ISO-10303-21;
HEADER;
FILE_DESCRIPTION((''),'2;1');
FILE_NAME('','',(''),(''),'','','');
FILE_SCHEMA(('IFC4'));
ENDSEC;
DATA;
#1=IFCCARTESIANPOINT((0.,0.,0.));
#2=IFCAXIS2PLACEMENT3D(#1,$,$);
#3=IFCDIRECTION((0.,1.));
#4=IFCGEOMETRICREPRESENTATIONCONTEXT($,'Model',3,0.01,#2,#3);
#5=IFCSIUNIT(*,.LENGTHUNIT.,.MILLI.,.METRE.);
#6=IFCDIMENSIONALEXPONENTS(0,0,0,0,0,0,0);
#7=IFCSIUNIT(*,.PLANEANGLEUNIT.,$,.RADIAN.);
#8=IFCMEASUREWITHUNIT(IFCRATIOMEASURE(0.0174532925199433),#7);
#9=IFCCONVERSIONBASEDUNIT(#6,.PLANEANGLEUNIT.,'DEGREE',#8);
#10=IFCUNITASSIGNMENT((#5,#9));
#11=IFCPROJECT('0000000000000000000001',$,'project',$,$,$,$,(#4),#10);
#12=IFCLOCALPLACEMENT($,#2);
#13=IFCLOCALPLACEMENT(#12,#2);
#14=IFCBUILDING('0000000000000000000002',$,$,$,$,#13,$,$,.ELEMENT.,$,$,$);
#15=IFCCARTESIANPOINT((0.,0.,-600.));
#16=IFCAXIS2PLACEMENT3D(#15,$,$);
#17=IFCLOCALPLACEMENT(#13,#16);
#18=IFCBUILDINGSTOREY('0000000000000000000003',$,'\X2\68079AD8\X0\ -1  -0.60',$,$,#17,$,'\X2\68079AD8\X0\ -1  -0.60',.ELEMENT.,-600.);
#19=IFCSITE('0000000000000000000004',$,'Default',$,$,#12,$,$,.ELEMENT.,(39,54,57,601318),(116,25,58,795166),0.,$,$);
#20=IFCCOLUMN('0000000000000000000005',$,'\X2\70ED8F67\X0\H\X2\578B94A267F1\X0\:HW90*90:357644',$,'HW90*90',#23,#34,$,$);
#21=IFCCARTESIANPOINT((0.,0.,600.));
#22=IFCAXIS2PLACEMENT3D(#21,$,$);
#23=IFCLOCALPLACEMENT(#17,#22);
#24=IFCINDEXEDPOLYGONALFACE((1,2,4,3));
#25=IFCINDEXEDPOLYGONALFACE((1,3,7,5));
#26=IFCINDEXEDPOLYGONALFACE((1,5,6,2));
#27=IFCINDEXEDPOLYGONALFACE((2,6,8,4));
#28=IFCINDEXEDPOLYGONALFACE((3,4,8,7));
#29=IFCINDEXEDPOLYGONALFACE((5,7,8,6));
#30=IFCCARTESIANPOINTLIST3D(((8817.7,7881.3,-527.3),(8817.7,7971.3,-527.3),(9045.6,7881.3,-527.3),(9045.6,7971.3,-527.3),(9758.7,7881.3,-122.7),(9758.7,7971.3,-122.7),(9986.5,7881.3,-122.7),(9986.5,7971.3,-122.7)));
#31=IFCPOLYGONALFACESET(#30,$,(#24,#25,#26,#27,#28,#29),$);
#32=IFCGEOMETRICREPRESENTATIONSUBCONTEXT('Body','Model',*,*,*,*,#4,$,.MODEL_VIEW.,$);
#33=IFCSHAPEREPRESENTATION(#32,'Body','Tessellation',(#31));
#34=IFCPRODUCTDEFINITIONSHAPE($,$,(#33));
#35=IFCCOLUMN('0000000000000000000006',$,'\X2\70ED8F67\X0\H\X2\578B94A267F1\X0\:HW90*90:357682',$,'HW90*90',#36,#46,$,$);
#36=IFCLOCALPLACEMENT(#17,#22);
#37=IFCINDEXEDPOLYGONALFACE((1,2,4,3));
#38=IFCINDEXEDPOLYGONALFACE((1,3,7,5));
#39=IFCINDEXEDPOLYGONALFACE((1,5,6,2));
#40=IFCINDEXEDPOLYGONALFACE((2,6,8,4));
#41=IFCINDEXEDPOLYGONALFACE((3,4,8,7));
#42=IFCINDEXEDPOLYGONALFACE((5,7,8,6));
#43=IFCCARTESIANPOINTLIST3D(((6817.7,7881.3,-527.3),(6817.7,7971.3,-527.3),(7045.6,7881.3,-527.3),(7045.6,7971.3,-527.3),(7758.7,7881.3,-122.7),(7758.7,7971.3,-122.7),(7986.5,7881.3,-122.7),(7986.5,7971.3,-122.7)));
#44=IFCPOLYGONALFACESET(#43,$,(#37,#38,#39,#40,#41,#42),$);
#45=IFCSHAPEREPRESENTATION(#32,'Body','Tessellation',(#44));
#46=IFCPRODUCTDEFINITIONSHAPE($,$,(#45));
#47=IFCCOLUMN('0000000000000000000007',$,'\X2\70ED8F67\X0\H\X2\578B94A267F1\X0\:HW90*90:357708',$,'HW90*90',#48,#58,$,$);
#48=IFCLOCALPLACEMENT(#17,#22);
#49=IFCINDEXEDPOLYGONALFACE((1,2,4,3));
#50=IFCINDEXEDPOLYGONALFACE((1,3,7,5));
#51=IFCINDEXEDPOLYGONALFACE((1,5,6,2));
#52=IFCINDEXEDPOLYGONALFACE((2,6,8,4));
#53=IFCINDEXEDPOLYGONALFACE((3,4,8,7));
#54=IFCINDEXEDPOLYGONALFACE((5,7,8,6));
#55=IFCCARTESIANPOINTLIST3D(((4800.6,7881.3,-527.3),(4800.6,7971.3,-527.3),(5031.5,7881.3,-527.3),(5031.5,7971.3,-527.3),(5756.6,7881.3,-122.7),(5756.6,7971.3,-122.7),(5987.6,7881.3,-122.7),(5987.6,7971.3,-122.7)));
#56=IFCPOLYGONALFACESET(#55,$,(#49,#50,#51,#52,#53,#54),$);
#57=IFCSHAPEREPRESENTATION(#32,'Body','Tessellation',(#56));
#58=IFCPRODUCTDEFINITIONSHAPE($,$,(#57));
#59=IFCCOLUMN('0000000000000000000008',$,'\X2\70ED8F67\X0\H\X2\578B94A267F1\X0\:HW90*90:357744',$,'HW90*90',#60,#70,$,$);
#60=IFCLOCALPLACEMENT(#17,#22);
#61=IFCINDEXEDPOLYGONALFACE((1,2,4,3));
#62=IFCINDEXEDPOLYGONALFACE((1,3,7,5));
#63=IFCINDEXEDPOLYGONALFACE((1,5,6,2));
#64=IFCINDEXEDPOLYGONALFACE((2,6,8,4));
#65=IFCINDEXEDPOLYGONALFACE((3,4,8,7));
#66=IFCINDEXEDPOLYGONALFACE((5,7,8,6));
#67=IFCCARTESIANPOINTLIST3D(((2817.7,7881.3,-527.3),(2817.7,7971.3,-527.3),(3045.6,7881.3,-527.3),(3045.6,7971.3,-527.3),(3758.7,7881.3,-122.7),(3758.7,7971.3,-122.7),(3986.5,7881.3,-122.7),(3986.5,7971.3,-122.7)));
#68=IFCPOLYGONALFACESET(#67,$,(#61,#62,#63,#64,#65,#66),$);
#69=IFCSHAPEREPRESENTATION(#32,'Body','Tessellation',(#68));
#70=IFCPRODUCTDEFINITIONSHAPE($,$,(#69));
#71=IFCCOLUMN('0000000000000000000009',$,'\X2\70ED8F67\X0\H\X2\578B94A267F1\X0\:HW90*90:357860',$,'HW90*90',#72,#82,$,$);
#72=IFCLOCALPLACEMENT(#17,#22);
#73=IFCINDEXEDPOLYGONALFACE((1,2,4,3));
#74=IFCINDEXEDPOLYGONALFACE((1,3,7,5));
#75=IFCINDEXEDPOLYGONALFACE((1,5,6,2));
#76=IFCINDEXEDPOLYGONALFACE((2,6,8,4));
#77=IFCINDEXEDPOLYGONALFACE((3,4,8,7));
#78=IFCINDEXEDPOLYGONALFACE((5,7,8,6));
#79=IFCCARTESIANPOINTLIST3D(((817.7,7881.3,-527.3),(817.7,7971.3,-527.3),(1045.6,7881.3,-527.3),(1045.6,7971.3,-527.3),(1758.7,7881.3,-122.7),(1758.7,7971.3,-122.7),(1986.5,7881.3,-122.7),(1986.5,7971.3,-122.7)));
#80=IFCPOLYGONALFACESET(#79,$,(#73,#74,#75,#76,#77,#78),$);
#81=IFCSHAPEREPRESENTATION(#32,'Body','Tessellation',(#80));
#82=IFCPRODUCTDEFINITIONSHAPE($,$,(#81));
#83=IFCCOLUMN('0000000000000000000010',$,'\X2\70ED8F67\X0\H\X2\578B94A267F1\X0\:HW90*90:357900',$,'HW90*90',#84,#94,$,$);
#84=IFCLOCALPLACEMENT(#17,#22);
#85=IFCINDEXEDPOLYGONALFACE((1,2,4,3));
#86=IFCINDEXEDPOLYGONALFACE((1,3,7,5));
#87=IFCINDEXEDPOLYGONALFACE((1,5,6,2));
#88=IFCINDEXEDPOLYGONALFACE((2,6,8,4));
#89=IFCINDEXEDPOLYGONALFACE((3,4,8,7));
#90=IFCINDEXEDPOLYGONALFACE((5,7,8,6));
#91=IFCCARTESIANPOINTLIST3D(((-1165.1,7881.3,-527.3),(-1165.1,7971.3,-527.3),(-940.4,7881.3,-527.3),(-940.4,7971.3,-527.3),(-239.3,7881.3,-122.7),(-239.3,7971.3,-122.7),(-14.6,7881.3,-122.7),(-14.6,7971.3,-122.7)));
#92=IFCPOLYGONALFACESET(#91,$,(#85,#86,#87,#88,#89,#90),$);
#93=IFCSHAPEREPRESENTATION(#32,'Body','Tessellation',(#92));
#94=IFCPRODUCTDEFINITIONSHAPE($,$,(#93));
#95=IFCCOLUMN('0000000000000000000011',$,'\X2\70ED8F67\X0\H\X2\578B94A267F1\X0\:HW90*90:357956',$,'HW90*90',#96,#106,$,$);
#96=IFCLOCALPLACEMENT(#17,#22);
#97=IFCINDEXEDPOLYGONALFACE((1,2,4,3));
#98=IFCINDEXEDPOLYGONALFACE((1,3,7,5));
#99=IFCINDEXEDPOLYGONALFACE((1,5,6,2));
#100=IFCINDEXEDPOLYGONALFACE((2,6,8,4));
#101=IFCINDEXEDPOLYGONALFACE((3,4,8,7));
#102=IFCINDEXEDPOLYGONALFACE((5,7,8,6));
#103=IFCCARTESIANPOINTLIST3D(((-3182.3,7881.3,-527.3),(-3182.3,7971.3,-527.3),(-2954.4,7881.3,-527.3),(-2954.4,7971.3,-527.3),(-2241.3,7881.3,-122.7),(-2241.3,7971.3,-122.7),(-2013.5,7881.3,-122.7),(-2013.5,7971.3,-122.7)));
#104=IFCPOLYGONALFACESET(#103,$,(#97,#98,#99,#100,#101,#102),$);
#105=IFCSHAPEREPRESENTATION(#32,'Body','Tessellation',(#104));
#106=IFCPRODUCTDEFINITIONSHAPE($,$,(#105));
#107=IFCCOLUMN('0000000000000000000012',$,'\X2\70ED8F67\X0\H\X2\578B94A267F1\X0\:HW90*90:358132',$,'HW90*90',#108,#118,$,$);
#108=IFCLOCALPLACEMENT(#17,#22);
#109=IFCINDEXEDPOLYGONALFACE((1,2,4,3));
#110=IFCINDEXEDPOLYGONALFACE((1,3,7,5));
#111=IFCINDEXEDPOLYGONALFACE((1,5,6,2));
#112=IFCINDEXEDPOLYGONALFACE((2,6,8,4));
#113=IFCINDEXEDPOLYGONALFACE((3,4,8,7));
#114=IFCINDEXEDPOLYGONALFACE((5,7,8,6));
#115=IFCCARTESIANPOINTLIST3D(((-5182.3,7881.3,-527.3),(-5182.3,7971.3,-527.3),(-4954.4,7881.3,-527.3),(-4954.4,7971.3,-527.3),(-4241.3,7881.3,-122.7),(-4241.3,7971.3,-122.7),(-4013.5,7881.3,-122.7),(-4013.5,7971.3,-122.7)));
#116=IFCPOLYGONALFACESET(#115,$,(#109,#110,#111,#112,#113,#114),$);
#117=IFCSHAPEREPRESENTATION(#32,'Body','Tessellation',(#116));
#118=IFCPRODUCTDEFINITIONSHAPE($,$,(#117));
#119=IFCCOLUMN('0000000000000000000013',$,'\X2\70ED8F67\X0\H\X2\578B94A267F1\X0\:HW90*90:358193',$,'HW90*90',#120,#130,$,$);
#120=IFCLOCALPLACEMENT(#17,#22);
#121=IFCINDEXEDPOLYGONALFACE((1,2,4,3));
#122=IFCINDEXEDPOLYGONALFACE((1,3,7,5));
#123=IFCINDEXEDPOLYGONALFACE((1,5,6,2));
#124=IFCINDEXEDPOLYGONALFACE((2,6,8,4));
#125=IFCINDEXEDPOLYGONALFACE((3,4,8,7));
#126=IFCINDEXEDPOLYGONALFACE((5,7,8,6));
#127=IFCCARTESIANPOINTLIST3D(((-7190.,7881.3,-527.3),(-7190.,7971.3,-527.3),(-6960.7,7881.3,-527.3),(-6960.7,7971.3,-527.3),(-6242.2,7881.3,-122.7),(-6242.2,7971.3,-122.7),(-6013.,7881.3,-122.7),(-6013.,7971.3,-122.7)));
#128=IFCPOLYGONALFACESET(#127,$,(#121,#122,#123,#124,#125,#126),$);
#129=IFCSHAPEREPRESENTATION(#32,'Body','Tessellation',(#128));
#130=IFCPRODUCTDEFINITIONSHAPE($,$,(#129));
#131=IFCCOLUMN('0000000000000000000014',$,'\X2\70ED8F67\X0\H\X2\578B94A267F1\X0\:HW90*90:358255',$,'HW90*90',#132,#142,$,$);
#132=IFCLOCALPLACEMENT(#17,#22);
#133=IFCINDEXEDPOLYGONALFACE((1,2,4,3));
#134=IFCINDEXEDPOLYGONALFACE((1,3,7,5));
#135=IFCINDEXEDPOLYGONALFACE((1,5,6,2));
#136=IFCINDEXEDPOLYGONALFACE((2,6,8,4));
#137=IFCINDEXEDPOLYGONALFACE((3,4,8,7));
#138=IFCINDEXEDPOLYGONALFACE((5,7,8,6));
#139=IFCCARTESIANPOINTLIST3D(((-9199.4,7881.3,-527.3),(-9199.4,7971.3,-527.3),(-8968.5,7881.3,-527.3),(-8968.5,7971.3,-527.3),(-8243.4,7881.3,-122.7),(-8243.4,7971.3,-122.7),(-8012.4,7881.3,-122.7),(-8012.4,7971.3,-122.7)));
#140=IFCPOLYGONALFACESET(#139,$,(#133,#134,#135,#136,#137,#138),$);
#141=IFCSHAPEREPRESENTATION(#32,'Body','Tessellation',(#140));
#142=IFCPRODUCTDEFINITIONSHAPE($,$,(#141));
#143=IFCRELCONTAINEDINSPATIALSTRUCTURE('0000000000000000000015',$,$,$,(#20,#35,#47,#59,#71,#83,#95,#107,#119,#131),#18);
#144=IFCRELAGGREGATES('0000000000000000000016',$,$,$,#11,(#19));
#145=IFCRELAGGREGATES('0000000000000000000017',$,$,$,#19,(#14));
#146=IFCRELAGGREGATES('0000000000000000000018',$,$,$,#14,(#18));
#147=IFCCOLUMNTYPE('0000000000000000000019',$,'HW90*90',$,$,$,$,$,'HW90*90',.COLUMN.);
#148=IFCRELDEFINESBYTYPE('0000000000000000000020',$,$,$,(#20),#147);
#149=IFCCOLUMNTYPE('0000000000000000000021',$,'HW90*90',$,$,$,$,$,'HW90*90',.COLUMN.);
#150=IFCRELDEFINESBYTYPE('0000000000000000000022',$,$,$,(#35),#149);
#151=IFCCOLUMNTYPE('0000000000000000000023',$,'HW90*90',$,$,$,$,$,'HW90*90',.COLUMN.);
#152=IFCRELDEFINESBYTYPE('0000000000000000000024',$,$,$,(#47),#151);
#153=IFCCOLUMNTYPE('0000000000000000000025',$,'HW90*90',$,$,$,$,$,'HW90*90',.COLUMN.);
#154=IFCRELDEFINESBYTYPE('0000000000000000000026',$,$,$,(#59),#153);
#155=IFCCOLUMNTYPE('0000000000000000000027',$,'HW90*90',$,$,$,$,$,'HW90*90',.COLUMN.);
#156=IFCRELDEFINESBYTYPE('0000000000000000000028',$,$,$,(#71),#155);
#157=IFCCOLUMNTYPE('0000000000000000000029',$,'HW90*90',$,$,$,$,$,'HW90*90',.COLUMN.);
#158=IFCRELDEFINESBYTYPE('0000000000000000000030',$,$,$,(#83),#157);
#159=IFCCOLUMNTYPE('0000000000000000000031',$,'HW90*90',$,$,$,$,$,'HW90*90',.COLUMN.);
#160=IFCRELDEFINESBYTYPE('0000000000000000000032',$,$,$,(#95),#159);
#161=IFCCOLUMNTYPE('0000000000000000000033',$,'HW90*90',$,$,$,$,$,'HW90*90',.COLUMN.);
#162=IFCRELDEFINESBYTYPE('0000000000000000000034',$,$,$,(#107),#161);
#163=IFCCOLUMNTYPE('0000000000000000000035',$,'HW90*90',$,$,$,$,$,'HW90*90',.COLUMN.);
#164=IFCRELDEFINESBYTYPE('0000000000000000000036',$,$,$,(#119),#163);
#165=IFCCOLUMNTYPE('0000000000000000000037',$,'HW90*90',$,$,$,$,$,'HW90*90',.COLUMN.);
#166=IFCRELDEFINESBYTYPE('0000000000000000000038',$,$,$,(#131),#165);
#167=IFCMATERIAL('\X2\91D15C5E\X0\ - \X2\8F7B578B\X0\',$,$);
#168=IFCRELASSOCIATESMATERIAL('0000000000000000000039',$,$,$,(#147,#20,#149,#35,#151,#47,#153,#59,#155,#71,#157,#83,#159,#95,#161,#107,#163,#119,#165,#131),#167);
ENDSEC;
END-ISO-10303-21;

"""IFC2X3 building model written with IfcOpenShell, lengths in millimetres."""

from ifc_helpers import new_model, entity, si_unit, converted_unit, direction, frame, frame_2d, origin, origin_2d_with_axis, place, context, subcontext, project, spatial, rectangle, extrude, clip, halfspace, source, transform, mapped, material, type_object, type_shapes, element, save


model = new_model("IFC2X3")

# Units and contexts
model_context = context("Model", 3, precision=0.01, world=origin(), true_north=direction((0.0, 1.0)))
body_context = subcontext(model_context, "Body", "Model", "MODEL_VIEW")
ifc_project = project(units=[si_unit("LENGTHUNIT", "METRE", prefix="MILLI"), converted_unit("PLANEANGLEUNIT", "DEGREE", entity("IfcRatioMeasure", 0.0174532925199433), si_unit("PLANEANGLEUNIT", "RADIAN"), dimensions=[0, 0, 0, 0, 0, 0, 0])], contexts=[model_context])

# Site, building, storey
site_placement = place(None, origin())
site = spatial("IfcSite", under=ifc_project, at=site_placement, Name="Default", CompositionType="ELEMENT", RefLatitude=(39, 54, 57, 601318), RefLongitude=(116, 25, 58, 795166), RefElevation=0.0)
building_placement = place(site_placement, origin())
building = spatial("IfcBuilding", under=site, at=building_placement, CompositionType="ELEMENT")
storey_placement = place(building_placement, frame((0.0, 0.0, -600.0)))
storey = spatial("IfcBuildingStorey", under=building, at=storey_placement, Name="标高 -1  -0.60", LongName="标高 -1  -0.60", CompositionType="ELEMENT", Elevation=-600.0)

# Columns
ifc_material = material(Name="金属 - 轻型")
column_type_1 = type_object("IfcColumnType", Name="HW90*90", ElementType="HW90*90", PredefinedType="COLUMN", material=ifc_material)
shared_shape_1 = source(origin(), body_context, "Body", "Clipping", [
    clip(clip(extrude(rectangle(XDim=90.0, YDim=1168.8, at=frame_2d((0.0, 0.0), x_axis=(1.0, 0.0))), frame((9402.1, 7926.3, -527.3), z_axis=(0.0, 0.0, 1.0), x_axis=(0.0, -1.0, 0.0)), (0.0, 0.0, 1.0), 404.6), halfspace(frame((10150.8, 7971.3, 45.9), z_axis=(-0.395028, 0.0, 0.918669), x_axis=(-0.918669, 0.0, -0.395028)), False)), halfspace(frame((10186.4, 7881.3, -36.8), z_axis=(0.395028, 0.0, -0.918669), x_axis=(-0.918669, 0.0, -0.395028)), False)),
])
type_shapes(column_type_1, [shared_shape_1])
column_1_placement = place(storey_placement, frame((0.0, 0.0, 600.0)))
element("IfcColumn", 1, at=column_1_placement, inside=storey, type_object=column_type_1, material=ifc_material, Name="热轧H型钢柱:HW90*90:357644", ObjectType="HW90*90", context=body_context, shape_type="MappedRepresentation", body=[
    mapped(shared_shape_1, transform((0.0, 0.0, 0.0), scale=1.0)),
])
column_type_2 = type_object("IfcColumnType", Name="HW90*90", ElementType="HW90*90", PredefinedType="COLUMN", material=ifc_material)
shared_shape_2 = source(origin(), body_context, "Body", "Clipping", [
    clip(clip(extrude(rectangle(XDim=90.0, YDim=1168.8, at=frame_2d((0.0, 0.0), x_axis=(1.0, 0.0))), frame((7402.1, 7926.3, -527.3), z_axis=(0.0, 0.0, 1.0), x_axis=(0.0, -1.0, 0.0)), (0.0, 0.0, 1.0), 404.6), halfspace(frame((8150.8, 7971.3, 45.9), z_axis=(-0.395028, 0.0, 0.918669), x_axis=(-0.918669, 0.0, -0.395028)), False)), halfspace(frame((8186.4, 7881.3, -36.8), z_axis=(0.395028, 0.0, -0.918669), x_axis=(-0.918669, 0.0, -0.395028)), False)),
])
type_shapes(column_type_2, [shared_shape_2])
column_2_placement = place(storey_placement, frame((0.0, 0.0, 600.0)))
element("IfcColumn", 2, at=column_2_placement, inside=storey, type_object=column_type_2, material=ifc_material, Name="热轧H型钢柱:HW90*90:357682", ObjectType="HW90*90", context=body_context, shape_type="MappedRepresentation", body=[
    mapped(shared_shape_2, transform((0.0, 0.0, 0.0), scale=1.0)),
])
column_type_3 = type_object("IfcColumnType", Name="HW90*90", ElementType="HW90*90", PredefinedType="COLUMN", material=ifc_material)
shared_shape_3 = source(origin(), body_context, "Body", "Clipping", [
    clip(clip(extrude(rectangle(XDim=90.0, YDim=1187.0, at=frame_2d((0.0, 0.0), x_axis=(1.0, 0.0))), frame((5394.1, 7926.3, -527.3), z_axis=(0.0, 0.0, 1.0), x_axis=(0.0, -1.0, 0.0)), (0.0, 0.0, 1.0), 404.6), halfspace(frame((6155.3, 7971.3, 46.0), z_axis=(-0.389735, 0.0, 0.920927), x_axis=(-0.920927, 0.0, -0.389735)), False)), halfspace(frame((6190.4, 7881.3, -36.9), z_axis=(0.389735, 0.0, -0.920927), x_axis=(-0.920927, 0.0, -0.389735)), False)),
])
type_shapes(column_type_3, [shared_shape_3])
column_3_placement = place(storey_placement, frame((0.0, 0.0, 600.0)))
element("IfcColumn", 3, at=column_3_placement, inside=storey, type_object=column_type_3, material=ifc_material, Name="热轧H型钢柱:HW90*90:357708", ObjectType="HW90*90", context=body_context, shape_type="MappedRepresentation", body=[
    mapped(shared_shape_3, transform((0.0, 0.0, 0.0), scale=1.0)),
])
column_type_4 = type_object("IfcColumnType", Name="HW90*90", ElementType="HW90*90", PredefinedType="COLUMN", material=ifc_material)
shared_shape_4 = source(origin(), body_context, "Body", "Clipping", [
    clip(clip(extrude(rectangle(XDim=90.0, YDim=1168.8, at=frame_2d((0.0, 0.0), x_axis=(1.0, 0.0))), frame((3402.1, 7926.3, -527.3), z_axis=(0.0, 0.0, 1.0), x_axis=(0.0, -1.0, 0.0)), (0.0, 0.0, 1.0), 404.6), halfspace(frame((4150.8, 7971.3, 45.9), z_axis=(-0.395028, 0.0, 0.918669), x_axis=(-0.918669, 0.0, -0.395028)), False)), halfspace(frame((4186.4, 7881.3, -36.8), z_axis=(0.395028, 0.0, -0.918669), x_axis=(-0.918669, 0.0, -0.395028)), False)),
])
type_shapes(column_type_4, [shared_shape_4])
column_4_placement = place(storey_placement, frame((0.0, 0.0, 600.0)))
element("IfcColumn", 4, at=column_4_placement, inside=storey, type_object=column_type_4, material=ifc_material, Name="热轧H型钢柱:HW90*90:357744", ObjectType="HW90*90", context=body_context, shape_type="MappedRepresentation", body=[
    mapped(shared_shape_4, transform((0.0, 0.0, 0.0), scale=1.0)),
])
column_type_5 = type_object("IfcColumnType", Name="HW90*90", ElementType="HW90*90", PredefinedType="COLUMN", material=ifc_material)
shared_shape_5 = source(origin(), body_context, "Body", "Clipping", [
    clip(clip(extrude(rectangle(XDim=90.0, YDim=1168.8, at=frame_2d((0.0, 0.0), x_axis=(1.0, 0.0))), frame((1402.1, 7926.3, -527.3), z_axis=(0.0, 0.0, 1.0), x_axis=(0.0, -1.0, 0.0)), (0.0, 0.0, 1.0), 404.6), halfspace(frame((2150.8, 7971.3, 45.9), z_axis=(-0.395028, 0.0, 0.918669), x_axis=(-0.918669, 0.0, -0.395028)), False)), halfspace(frame((2186.4, 7881.3, -36.8), z_axis=(0.395028, 0.0, -0.918669), x_axis=(-0.918669, 0.0, -0.395028)), False)),
])
type_shapes(column_type_5, [shared_shape_5])
column_5_placement = place(storey_placement, frame((0.0, 0.0, 600.0)))
element("IfcColumn", 5, at=column_5_placement, inside=storey, type_object=column_type_5, material=ifc_material, Name="热轧H型钢柱:HW90*90:357860", ObjectType="HW90*90", context=body_context, shape_type="MappedRepresentation", body=[
    mapped(shared_shape_5, transform((0.0, 0.0, 0.0), scale=1.0)),
])
column_type_6 = type_object("IfcColumnType", Name="HW90*90", ElementType="HW90*90", PredefinedType="COLUMN", material=ifc_material)
shared_shape_6 = source(origin(), body_context, "Body", "Clipping", [
    clip(clip(extrude(rectangle(XDim=90.0, YDim=1150.6, at=frame_2d((0.0, 0.0), x_axis=(1.0, 0.0))), frame((-589.8, 7926.3, -527.3), z_axis=(0.0, 0.0, 1.0), x_axis=(0.0, -1.0, 0.0)), (0.0, 0.0, 1.0), 404.6), halfspace(frame((182.3, 7881.3, -36.7), z_axis=(0.400452, 0.0, -0.916318), x_axis=(-0.916318, 0.0, -0.400452)), False)), halfspace(frame((146.3, 7971.3, 45.8), z_axis=(-0.400452, 0.0, 0.916318), x_axis=(-0.916318, 0.0, -0.400452)), False)),
])
type_shapes(column_type_6, [shared_shape_6])
column_6_placement = place(storey_placement, frame((0.0, 0.0, 600.0)))
element("IfcColumn", 6, at=column_6_placement, inside=storey, type_object=column_type_6, material=ifc_material, Name="热轧H型钢柱:HW90*90:357900", ObjectType="HW90*90", context=body_context, shape_type="MappedRepresentation", body=[
    mapped(shared_shape_6, transform((0.0, 0.0, 0.0), scale=1.0)),
])
column_type_7 = type_object("IfcColumnType", Name="HW90*90", ElementType="HW90*90", PredefinedType="COLUMN", material=ifc_material)
shared_shape_7 = source(origin(), body_context, "Body", "Clipping", [
    clip(clip(extrude(rectangle(XDim=90.0, YDim=1168.8, at=frame_2d((0.0, 0.0), x_axis=(1.0, 0.0))), frame((-2597.9, 7926.3, -527.3), z_axis=(0.0, 0.0, 1.0), x_axis=(0.0, -1.0, 0.0)), (0.0, 0.0, 1.0), 404.6), halfspace(frame((-1813.6, 7881.3, -36.8), z_axis=(0.395028, 0.0, -0.918669), x_axis=(-0.918669, 0.0, -0.395028)), False)), halfspace(frame((-1849.2, 7971.3, 45.9), z_axis=(-0.395028, 0.0, 0.918669), x_axis=(-0.918669, 0.0, -0.395028)), False)),
])
type_shapes(column_type_7, [shared_shape_7])
column_7_placement = place(storey_placement, frame((0.0, 0.0, 600.0)))
element("IfcColumn", 7, at=column_7_placement, inside=storey, type_object=column_type_7, material=ifc_material, Name="热轧H型钢柱:HW90*90:357956", ObjectType="HW90*90", context=body_context, shape_type="MappedRepresentation", body=[
    mapped(shared_shape_7, transform((0.0, 0.0, 0.0), scale=1.0)),
])
column_type_8 = type_object("IfcColumnType", Name="HW90*90", ElementType="HW90*90", PredefinedType="COLUMN", material=ifc_material)
shared_shape_8 = source(origin(), body_context, "Body", "Clipping", [
    clip(clip(extrude(rectangle(XDim=90.0, YDim=1168.8, at=frame_2d((0.0, 0.0), x_axis=(1.0, 0.0))), frame((-4597.9, 7926.3, -527.3), z_axis=(0.0, 0.0, 1.0), x_axis=(0.0, -1.0, 0.0)), (0.0, 0.0, 1.0), 404.6), halfspace(frame((-3813.6, 7881.3, -36.8), z_axis=(0.395028, 0.0, -0.918669), x_axis=(-0.918669, 0.0, -0.395028)), False)), halfspace(frame((-3849.2, 7971.3, 45.9), z_axis=(-0.395028, 0.0, 0.918669), x_axis=(-0.918669, 0.0, -0.395028)), False)),
])
type_shapes(column_type_8, [shared_shape_8])
column_8_placement = place(storey_placement, frame((0.0, 0.0, 600.0)))
element("IfcColumn", 8, at=column_8_placement, inside=storey, type_object=column_type_8, material=ifc_material, Name="热轧H型钢柱:HW90*90:358132", ObjectType="HW90*90", context=body_context, shape_type="MappedRepresentation", body=[
    mapped(shared_shape_8, transform((0.0, 0.0, 0.0), scale=1.0)),
])
column_type_9 = type_object("IfcColumnType", Name="HW90*90", ElementType="HW90*90", PredefinedType="COLUMN", material=ifc_material)
shared_shape_9 = source(origin(), body_context, "Body", "Clipping", [
    clip(clip(extrude(rectangle(XDim=90.0, YDim=1177.0, at=frame_2d((0.0, 0.0), x_axis=(1.0, 0.0))), frame((-6601.5, 7926.3, -527.3), z_axis=(0.0, 0.0, 1.0), x_axis=(0.0, -1.0, 0.0)), (0.0, 0.0, 1.0), 404.6), halfspace(frame((-5811.8, 7881.3, -36.8), z_axis=(0.392632, 0.0, -0.919696), x_axis=(-0.919696, 0.0, -0.392632)), False)), halfspace(frame((-5847.2, 7971.3, 46.0), z_axis=(-0.392632, 0.0, 0.919696), x_axis=(-0.919696, 0.0, -0.392632)), False)),
])
type_shapes(column_type_9, [shared_shape_9])
column_9_placement = place(storey_placement, frame((0.0, 0.0, 600.0)))
element("IfcColumn", 9, at=column_9_placement, inside=storey, type_object=column_type_9, material=ifc_material, Name="热轧H型钢柱:HW90*90:358193", ObjectType="HW90*90", context=body_context, shape_type="MappedRepresentation", body=[
    mapped(shared_shape_9, transform((0.0, 0.0, 0.0), scale=1.0)),
])
column_type_10 = type_object("IfcColumnType", Name="HW90*90", ElementType="HW90*90", PredefinedType="COLUMN", material=ifc_material)
shared_shape_10 = source(origin(), body_context, "Body", "Clipping", [
    clip(clip(extrude(rectangle(XDim=90.0, YDim=1187.0, at=origin_2d_with_axis()), frame((-8605.9, 7926.3, -527.3), z_axis=(0.0, 0.0, 1.0), x_axis=(0.0, -1.0, 0.0)), (0.0, 0.0, 1.0), 404.6), halfspace(frame((-7844.7, 7971.3, 46.0), z_axis=(-0.389735, 0.0, 0.920927), x_axis=(-0.920927, 0.0, -0.389735)), False)), halfspace(frame((-7809.6, 7881.3, -36.9), z_axis=(0.389735, 0.0, -0.920927), x_axis=(-0.920927, 0.0, -0.389735)), False)),
])
type_shapes(column_type_10, [shared_shape_10])
column_10_placement = place(storey_placement, frame((0.0, 0.0, 600.0)))
element("IfcColumn", 10, at=column_10_placement, inside=storey, type_object=column_type_10, material=ifc_material, Name="热轧H型钢柱:HW90*90:358255", ObjectType="HW90*90", context=body_context, shape_type="MappedRepresentation", body=[
    mapped(shared_shape_10, transform((0.0, 0.0, 0.0), scale=1.0)),
])

save(model, "model.ifc")
